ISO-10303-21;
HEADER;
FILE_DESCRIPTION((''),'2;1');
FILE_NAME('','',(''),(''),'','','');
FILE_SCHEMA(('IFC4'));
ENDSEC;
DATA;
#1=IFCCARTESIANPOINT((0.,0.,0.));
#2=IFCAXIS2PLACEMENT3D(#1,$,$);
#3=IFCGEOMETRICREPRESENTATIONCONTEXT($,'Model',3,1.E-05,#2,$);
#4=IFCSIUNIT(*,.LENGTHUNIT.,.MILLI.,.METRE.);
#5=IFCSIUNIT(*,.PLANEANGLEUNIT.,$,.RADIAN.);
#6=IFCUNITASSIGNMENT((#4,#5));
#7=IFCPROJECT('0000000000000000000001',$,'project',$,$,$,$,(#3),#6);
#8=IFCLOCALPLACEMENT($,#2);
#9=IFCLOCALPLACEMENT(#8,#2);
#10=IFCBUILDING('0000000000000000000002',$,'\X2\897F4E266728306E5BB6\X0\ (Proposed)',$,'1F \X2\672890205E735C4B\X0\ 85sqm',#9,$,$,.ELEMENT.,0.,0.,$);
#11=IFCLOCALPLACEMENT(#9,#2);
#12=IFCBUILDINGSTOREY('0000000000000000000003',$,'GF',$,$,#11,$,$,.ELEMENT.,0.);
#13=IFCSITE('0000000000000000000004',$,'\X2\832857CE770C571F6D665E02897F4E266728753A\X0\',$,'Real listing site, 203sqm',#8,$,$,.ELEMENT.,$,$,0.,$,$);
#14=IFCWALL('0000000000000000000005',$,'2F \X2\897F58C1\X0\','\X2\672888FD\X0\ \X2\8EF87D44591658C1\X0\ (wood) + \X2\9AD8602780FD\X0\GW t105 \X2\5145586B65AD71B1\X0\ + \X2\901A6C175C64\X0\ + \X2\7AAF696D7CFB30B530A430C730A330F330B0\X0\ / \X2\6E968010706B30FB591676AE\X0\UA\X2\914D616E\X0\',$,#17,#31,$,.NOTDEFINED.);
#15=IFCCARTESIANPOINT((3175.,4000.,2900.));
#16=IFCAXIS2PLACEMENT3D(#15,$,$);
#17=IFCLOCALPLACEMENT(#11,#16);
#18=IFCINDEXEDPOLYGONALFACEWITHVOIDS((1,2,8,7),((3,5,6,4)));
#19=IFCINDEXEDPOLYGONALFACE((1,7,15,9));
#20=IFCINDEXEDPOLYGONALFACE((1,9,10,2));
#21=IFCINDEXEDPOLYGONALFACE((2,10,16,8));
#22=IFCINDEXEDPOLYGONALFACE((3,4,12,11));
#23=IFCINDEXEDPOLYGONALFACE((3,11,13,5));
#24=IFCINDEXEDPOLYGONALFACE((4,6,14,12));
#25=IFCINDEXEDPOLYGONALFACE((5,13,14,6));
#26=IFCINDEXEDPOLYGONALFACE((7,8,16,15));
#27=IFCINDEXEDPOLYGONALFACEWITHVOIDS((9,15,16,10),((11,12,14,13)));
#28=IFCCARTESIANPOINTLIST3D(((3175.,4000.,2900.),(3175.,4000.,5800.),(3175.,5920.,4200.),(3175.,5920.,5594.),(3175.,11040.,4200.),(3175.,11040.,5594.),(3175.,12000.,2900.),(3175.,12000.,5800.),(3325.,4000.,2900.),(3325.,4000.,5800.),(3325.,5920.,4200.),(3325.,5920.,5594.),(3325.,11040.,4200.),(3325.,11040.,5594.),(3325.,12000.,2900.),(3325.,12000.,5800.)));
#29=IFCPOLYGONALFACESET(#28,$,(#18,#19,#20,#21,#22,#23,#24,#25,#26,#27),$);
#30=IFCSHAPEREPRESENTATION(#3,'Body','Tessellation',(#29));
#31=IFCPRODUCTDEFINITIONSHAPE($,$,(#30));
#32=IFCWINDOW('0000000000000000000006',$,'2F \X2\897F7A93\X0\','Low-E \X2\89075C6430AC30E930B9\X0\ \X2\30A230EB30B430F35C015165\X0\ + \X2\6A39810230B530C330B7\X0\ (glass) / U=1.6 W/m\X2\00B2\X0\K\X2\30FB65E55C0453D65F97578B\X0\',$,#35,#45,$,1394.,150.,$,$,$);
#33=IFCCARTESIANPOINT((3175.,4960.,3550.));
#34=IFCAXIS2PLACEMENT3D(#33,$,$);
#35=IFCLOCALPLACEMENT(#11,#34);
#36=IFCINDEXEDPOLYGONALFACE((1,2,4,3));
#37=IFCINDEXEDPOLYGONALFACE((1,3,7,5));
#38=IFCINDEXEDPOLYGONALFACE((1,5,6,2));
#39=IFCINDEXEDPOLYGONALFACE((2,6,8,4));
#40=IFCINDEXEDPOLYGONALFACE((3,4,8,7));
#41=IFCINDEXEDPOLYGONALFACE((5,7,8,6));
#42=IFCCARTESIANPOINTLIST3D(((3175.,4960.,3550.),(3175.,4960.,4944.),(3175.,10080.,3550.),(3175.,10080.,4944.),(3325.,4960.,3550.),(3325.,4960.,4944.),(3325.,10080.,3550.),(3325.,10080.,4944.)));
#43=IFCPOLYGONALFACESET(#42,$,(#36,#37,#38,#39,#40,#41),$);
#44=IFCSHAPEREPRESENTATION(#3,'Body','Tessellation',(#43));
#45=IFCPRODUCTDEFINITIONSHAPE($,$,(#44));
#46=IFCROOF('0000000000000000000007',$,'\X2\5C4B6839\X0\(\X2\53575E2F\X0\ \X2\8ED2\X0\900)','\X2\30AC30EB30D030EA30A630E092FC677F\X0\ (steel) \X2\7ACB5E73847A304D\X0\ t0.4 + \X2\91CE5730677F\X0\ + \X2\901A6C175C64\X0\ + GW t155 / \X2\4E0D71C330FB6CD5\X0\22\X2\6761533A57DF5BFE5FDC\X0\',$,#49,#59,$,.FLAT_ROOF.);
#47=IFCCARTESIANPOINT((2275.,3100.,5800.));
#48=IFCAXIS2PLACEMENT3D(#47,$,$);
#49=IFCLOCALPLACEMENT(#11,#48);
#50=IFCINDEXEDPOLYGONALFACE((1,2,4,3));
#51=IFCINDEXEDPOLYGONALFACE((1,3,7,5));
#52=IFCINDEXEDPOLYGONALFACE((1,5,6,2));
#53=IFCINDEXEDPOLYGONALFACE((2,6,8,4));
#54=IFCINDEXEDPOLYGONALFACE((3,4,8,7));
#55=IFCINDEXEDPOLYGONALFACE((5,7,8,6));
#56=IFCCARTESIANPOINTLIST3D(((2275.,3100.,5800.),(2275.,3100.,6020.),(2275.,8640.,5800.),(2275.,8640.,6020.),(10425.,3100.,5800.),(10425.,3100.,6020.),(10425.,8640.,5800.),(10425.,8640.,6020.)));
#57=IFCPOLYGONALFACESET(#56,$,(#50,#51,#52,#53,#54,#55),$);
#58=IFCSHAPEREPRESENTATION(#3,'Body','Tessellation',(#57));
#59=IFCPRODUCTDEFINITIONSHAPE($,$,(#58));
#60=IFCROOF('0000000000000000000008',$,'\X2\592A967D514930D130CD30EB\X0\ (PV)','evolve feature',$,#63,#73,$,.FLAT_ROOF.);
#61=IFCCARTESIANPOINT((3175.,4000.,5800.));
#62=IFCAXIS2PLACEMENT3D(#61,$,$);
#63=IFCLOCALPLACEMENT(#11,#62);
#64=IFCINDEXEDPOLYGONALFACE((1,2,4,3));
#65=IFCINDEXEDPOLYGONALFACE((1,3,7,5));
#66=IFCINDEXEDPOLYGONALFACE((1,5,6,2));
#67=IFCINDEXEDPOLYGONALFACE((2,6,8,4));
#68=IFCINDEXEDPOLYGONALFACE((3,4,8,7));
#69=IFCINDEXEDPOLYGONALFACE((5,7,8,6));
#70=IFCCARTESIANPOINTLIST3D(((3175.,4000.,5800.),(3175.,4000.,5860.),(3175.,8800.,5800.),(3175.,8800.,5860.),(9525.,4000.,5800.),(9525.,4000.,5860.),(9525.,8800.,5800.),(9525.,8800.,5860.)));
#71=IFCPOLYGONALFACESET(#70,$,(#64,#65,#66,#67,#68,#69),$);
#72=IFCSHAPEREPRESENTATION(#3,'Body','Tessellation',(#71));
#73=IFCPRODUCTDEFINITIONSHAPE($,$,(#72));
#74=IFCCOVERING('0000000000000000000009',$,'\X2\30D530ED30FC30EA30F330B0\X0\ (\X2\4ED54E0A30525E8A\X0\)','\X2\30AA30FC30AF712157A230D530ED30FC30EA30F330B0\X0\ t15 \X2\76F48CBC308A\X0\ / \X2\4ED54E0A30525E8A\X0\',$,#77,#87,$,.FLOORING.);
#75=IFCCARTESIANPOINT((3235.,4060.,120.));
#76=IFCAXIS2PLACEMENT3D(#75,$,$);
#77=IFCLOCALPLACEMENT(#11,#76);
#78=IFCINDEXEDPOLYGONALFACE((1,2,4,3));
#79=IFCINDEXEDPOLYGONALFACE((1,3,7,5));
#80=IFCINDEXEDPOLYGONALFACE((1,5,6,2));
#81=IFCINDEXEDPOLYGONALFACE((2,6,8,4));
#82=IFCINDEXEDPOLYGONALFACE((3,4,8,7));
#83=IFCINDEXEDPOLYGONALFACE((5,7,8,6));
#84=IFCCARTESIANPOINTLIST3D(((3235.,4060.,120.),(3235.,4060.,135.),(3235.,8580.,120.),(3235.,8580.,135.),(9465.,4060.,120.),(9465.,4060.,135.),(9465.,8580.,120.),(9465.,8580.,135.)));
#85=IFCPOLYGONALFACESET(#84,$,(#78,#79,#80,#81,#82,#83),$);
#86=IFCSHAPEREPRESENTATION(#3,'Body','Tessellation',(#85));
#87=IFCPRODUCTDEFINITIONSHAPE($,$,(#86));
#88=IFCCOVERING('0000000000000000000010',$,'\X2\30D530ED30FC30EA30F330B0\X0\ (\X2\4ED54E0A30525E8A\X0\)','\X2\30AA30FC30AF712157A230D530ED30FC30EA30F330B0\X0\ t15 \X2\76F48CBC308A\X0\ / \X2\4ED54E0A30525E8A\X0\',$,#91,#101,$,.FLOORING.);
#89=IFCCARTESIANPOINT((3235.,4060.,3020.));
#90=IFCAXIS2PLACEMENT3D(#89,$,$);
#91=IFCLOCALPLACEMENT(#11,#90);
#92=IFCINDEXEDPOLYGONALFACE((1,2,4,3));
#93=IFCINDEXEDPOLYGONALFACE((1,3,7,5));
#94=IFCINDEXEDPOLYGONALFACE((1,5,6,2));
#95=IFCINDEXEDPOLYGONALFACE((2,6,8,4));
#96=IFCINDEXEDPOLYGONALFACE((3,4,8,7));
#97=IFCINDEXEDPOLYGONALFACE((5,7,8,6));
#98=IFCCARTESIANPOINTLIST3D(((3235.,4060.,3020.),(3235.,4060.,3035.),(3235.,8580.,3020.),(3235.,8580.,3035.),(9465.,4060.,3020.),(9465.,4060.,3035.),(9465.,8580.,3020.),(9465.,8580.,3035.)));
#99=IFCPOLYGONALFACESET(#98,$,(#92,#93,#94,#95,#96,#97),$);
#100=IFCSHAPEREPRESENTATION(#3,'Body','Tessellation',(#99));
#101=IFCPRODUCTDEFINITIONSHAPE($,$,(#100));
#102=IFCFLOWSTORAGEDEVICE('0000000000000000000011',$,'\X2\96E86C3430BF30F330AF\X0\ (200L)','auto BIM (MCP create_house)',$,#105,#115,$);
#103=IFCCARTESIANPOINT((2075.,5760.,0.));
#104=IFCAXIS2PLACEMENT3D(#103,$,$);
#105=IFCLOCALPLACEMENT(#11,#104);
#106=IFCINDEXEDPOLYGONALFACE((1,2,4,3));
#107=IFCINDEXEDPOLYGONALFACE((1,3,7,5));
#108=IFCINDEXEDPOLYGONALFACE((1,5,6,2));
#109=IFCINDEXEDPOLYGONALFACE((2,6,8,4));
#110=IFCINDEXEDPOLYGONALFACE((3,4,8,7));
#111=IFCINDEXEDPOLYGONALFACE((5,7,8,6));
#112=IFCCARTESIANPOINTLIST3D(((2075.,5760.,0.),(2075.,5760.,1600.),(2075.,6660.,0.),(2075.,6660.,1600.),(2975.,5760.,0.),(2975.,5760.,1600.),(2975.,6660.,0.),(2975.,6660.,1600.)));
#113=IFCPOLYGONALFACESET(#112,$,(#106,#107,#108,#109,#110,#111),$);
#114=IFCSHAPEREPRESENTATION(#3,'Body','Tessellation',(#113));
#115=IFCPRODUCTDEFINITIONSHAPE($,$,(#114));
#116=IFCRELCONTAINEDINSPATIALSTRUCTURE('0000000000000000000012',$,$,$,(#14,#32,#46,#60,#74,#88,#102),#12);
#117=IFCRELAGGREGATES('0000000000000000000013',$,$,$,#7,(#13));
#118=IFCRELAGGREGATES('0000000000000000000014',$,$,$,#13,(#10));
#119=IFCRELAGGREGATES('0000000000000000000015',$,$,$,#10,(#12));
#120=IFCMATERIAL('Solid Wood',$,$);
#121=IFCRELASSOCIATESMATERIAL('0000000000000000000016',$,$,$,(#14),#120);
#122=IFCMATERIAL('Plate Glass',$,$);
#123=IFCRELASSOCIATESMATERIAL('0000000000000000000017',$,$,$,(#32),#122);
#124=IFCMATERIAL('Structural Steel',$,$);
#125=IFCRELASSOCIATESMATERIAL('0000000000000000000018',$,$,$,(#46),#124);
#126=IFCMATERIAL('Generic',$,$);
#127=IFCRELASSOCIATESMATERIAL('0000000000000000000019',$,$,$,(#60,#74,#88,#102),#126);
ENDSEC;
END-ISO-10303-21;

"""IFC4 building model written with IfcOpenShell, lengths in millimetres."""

from ifc_helpers import new_model, si_unit, frame, frame_2d, origin, place, context, project, spatial, rectangle, extrude, material, element, fill, save


model = new_model("IFC4")

# Units and contexts
model_context = context("Model", 3, precision=1e-05, world=origin())
ifc_project = project(units=[si_unit("LENGTHUNIT", "METRE", prefix="MILLI"), si_unit("PLANEANGLEUNIT", "RADIAN")], contexts=[model_context])

# Site, building, storey
site_placement = place(None, origin())
site = spatial("IfcSite", under=ifc_project, at=site_placement, Name="茨城県土浦市西並木町", ObjectType="Real listing site, 203sqm", CompositionType="ELEMENT", RefElevation=0.0)
building_placement = place(site_placement, origin())
building = spatial("IfcBuilding", under=site, at=building_placement, Name="西並木の家 (Proposed)", ObjectType="1F 木造平屋 85sqm", CompositionType="ELEMENT", ElevationOfRefHeight=0.0, ElevationOfTerrain=0.0)
storey_placement = place(building_placement, origin())
storey = spatial("IfcBuildingStorey", under=building, at=storey_placement, Name="GF", CompositionType="ELEMENT", Elevation=0.0)

# Shared definitions
ifc_material_1 = material(Name="Solid Wood")
ifc_material_2 = material(Name="Generic")

# Shared definitions
ifc_material_3 = material(Name="Plate Glass")

# Wall, opening, window
wall_1_placement = place(storey_placement, frame((3175.0, 4000.0, 2900.0)))
wall_1 = element("IfcWall", 1, at=wall_1_placement, inside=storey, material=ifc_material_1, Name="2F 西壁", Description="木製 軸組外壁 (wood) + 高性能GW t105 充填断熱 + 通気層 + 窯業系サイディング / 準耐火・外皮UA配慮", PredefinedType="NOTDEFINED", context=model_context, shape_type="SweptSolid", body=[
    extrude(rectangle(XDim=150.0, YDim=8000.0, at=frame_2d((75.0, 4000.0))), frame((3175.0, 4000.0, 2900.0)), (0.0, 0.0, 1.0), 2900.0),
])
opening_1_placement = place(storey_placement, frame((3175.0, 4960.0, 3550.0)))
opening_1 = element("IfcOpeningElement", 2, at=opening_1_placement, cuts=wall_1, PredefinedType="NOTDEFINED", context=model_context, shape_type="SweptSolid", body=[
    extrude(rectangle(XDim=150.0, YDim=5120.0, at=frame_2d((75.0, 2560.0))), frame((3175.0, 4960.0, 3550.0)), (0.0, 0.0, 1.0), 1394.0),
])
window_1_placement = place(storey_placement, frame((3175.0, 4960.0, 3550.0)))
window_1 = element("IfcWindow", 3, at=window_1_placement, inside=storey, material=ifc_material_3, Name="2F 西窓", Description="Low-E 複層ガラス アルゴン封入 + 樹脂サッシ (glass) / U=1.6 W/m²K・日射取得型", OverallHeight=1394.0, OverallWidth=150.0, context=model_context, shape_type="SweptSolid", body=[
    extrude(rectangle(XDim=150.0, YDim=5120.0, at=frame_2d((75.0, 2560.0))), frame((3175.0, 4960.0, 3550.0)), (0.0, 0.0, 1.0), 1394.0),
])
fill(opening_1, window_1)

# Roofs
ifc_material_4 = material(Name="Structural Steel")
for number, where, name in (
    (4, (2275.0, 3100.0, 5800.0), "屋根(南帯 軒900)"),
):
    element("IfcRoof", number, at=place(storey_placement, frame(where)), inside=storey, material=ifc_material_4, Name=name, Description="ガルバリウム鋼板 (steel) 立平葺き t0.4 + 野地板 + 通気層 + GW t155 / 不燃・法22条区域対応", PredefinedType="FLAT_ROOF", context=model_context, shape_type="SweptSolid", body=[
        extrude(rectangle(XDim=8150.0, YDim=5540.0, at=frame_2d((4075.0, 2770.0))), frame((2275.0, 3100.0, 5800.0)), (0.0, 0.0, 1.0), 220.0),
    ])
roof_placement = place(storey_placement, frame((3175.0, 4000.0, 5800.0)))
element("IfcRoof", 5, at=roof_placement, inside=storey, material=ifc_material_2, Name="太陽光パネル (PV)", Description="evolve feature", PredefinedType="FLAT_ROOF", context=model_context, shape_type="SweptSolid", body=[
    extrude(rectangle(XDim=6350.0, YDim=4800.0, at=frame_2d((3175.0, 2400.0))), frame((3175.0, 4000.0, 5800.0)), (0.0, 0.0, 1.0), 60.0),
])

# Coverings
covering_1_placement = place(storey_placement, frame((3235.0, 4060.0, 120.0)))
element("IfcCovering", 6, at=covering_1_placement, inside=storey, material=ifc_material_2, Name="フローリング (仕上げ床)", Description="オーク無垢フローリング t15 直貼り / 仕上げ床", PredefinedType="FLOORING", context=model_context, shape_type="SweptSolid", body=[
    extrude(rectangle(XDim=6230.0, YDim=4520.0, at=frame_2d((3115.0, 2260.0))), frame((3235.0, 4060.0, 120.0)), (0.0, 0.0, 1.0), 15.0),
])
covering_2_placement = place(storey_placement, frame((3235.0, 4060.0, 3020.0)))
element("IfcCovering", 7, at=covering_2_placement, inside=storey, material=ifc_material_2, Name="フローリング (仕上げ床)", Description="オーク無垢フローリング t15 直貼り / 仕上げ床", PredefinedType="FLOORING", context=model_context, shape_type="SweptSolid", body=[
    extrude(rectangle(XDim=6230.0, YDim=4520.0, at=frame_2d((3115.0, 2260.0))), frame((3235.0, 4060.0, 3020.0)), (0.0, 0.0, 1.0), 15.0),
])

# Flow storage device
flow_storage_device_placement = place(storey_placement, frame((2075.0, 5760.0, 0.0)))
element("IfcFlowStorageDevice", 8, at=flow_storage_device_placement, inside=storey, material=ifc_material_2, Name="雨水タンク (200L)", Description="auto BIM (MCP create_house)", context=model_context, shape_type="SweptSolid", body=[
    extrude(rectangle(XDim=900.0, YDim=900.0, at=frame_2d((450.0, 450.0))), frame((2075.0, 5760.0, 0.0)), (0.0, 0.0, 1.0), 1600.0),
])

save(model, "model.ifc")
